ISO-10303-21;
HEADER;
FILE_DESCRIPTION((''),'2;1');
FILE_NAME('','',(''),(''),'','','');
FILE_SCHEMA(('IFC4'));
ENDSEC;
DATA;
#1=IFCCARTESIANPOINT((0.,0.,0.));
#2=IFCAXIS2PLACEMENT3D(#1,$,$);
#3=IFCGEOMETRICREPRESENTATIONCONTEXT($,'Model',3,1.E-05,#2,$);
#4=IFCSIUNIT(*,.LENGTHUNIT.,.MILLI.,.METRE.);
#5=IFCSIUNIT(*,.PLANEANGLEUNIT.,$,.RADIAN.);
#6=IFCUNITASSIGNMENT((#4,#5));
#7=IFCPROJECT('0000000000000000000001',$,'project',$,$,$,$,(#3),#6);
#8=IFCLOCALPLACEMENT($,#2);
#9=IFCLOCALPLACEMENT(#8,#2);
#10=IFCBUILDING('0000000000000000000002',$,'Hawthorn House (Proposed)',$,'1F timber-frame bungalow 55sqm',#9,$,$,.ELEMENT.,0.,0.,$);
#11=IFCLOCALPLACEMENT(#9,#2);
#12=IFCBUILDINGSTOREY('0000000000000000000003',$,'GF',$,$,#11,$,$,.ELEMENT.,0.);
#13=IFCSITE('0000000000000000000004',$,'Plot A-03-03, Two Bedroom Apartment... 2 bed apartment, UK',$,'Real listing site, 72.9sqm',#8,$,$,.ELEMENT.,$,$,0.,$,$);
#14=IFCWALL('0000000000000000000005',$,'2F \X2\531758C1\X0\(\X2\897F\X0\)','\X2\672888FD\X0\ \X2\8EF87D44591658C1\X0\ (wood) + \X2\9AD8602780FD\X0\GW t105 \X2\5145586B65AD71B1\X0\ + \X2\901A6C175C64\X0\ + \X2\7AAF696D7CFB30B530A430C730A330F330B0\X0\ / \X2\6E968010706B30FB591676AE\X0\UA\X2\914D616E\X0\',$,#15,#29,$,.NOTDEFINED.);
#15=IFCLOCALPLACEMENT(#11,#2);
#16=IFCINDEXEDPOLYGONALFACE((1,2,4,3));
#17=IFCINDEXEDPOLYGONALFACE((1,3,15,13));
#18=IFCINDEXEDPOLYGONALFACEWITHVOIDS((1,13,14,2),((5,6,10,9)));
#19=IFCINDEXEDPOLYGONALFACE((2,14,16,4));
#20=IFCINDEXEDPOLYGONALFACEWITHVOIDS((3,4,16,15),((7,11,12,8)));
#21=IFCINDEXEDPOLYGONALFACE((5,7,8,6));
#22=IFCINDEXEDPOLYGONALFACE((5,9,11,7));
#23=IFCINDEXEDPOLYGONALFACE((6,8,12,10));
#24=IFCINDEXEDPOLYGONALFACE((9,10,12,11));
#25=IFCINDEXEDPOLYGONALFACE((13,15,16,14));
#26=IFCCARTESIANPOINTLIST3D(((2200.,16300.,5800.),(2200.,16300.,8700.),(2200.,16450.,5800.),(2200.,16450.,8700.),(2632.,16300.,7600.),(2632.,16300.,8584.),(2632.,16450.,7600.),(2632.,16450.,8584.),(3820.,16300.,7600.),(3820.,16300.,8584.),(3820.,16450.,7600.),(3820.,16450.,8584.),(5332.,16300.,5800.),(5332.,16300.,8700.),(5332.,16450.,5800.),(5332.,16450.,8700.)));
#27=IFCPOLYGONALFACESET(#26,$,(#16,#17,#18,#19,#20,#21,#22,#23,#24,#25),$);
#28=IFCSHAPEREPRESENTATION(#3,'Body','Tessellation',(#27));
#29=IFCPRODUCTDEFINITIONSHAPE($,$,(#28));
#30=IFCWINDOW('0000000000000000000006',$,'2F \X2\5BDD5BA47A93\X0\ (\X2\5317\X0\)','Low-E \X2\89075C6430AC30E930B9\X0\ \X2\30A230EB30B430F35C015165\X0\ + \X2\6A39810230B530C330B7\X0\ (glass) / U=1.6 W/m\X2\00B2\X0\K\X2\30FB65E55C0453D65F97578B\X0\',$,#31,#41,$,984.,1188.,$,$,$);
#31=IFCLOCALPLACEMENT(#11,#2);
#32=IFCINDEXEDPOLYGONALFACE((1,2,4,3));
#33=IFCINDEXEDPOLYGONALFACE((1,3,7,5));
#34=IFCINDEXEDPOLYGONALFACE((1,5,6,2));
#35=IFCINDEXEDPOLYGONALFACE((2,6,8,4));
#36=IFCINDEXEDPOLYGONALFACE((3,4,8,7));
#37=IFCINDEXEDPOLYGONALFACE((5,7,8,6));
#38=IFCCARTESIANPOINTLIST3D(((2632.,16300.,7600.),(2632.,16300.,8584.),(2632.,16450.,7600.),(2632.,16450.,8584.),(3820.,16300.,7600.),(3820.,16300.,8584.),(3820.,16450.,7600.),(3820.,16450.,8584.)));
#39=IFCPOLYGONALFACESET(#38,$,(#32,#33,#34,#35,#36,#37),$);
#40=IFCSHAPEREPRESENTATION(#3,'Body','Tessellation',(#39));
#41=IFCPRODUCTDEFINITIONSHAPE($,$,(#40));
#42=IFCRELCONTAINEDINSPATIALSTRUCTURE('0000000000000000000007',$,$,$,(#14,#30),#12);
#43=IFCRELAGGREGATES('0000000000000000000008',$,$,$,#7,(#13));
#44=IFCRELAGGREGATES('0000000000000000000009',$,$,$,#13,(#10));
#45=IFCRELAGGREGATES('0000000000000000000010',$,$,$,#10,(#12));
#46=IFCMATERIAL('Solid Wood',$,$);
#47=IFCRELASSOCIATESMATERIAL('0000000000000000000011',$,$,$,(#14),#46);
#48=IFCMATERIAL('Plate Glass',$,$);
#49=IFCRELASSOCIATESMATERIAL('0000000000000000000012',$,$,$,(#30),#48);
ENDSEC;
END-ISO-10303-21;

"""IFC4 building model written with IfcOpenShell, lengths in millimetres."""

from ifc_helpers import new_model, si_unit, frame, frame_2d, origin, place, context, project, spatial, rectangle, extrude, material, element, fill, save


model = new_model("IFC4")

# Units and contexts
model_context = context("Model", 3, precision=1e-05, world=origin())
ifc_project = project(units=[si_unit("LENGTHUNIT", "METRE", prefix="MILLI"), si_unit("PLANEANGLEUNIT", "RADIAN")], contexts=[model_context])

# Site, building, storey
site_placement = place(None, origin())
site = spatial("IfcSite", under=ifc_project, at=site_placement, Name="Plot A-03-03, Two Bedroom Apartment... 2 bed apartment, UK", ObjectType="Real listing site, 72.9sqm", CompositionType="ELEMENT", RefElevation=0.0)
building_placement = place(site_placement, origin())
building = spatial("IfcBuilding", under=site, at=building_placement, Name="Hawthorn House (Proposed)", ObjectType="1F timber-frame bungalow 55sqm", CompositionType="ELEMENT", ElevationOfRefHeight=0.0, ElevationOfTerrain=0.0)
storey_placement = place(building_placement, origin())
storey = spatial("IfcBuildingStorey", under=building, at=storey_placement, Name="GF", CompositionType="ELEMENT", Elevation=0.0)

# Shared definitions
ifc_material_1 = material(Name="Solid Wood")

# Wall, opening, window
wall_1_placement = place(storey_placement, frame((1100.0, 8150.0, 2900.0)))
wall_1 = element("IfcWall", 1, at=wall_1_placement, inside=storey, material=ifc_material_1, Name="2F 北壁(西)", Description="木製 軸組外壁 (wood) + 高性能GW t105 充填断熱 + 通気層 + 窯業系サイディング / 準耐火・外皮UA配慮", PredefinedType="NOTDEFINED", context=model_context, shape_type="SweptSolid", body=[
    extrude(rectangle(XDim=3132.0, YDim=150.0, at=frame_2d((1566.0, 75.0))), frame((1100.0, 8150.0, 2900.0)), (0.0, 0.0, 1.0), 2900.0),
])
opening_1_placement = place(storey_placement, frame((1316.0, 8150.0, 3800.0)))
opening_1 = element("IfcOpeningElement", 2, at=opening_1_placement, cuts=wall_1, PredefinedType="NOTDEFINED", context=model_context, shape_type="SweptSolid", body=[
    extrude(rectangle(XDim=1188.0, YDim=150.0, at=frame_2d((594.0, 75.0))), frame((1316.0, 8150.0, 3800.0)), (0.0, 0.0, 1.0), 984.0),
])
ifc_material_2 = material(Name="Plate Glass")
window_1_placement = place(storey_placement, frame((1316.0, 8150.0, 3800.0)))
window_1 = element("IfcWindow", 3, at=window_1_placement, inside=storey, material=ifc_material_2, Name="2F 寝室窓 (北)", Description="Low-E 複層ガラス アルゴン封入 + 樹脂サッシ (glass) / U=1.6 W/m²K・日射取得型", OverallHeight=984.0, OverallWidth=1188.0, context=model_context, shape_type="SweptSolid", body=[
    extrude(rectangle(XDim=1188.0, YDim=150.0, at=frame_2d((594.0, 75.0))), frame((1316.0, 8150.0, 3800.0)), (0.0, 0.0, 1.0), 984.0),
])
fill(opening_1, window_1)

save(model, "model.ifc")
